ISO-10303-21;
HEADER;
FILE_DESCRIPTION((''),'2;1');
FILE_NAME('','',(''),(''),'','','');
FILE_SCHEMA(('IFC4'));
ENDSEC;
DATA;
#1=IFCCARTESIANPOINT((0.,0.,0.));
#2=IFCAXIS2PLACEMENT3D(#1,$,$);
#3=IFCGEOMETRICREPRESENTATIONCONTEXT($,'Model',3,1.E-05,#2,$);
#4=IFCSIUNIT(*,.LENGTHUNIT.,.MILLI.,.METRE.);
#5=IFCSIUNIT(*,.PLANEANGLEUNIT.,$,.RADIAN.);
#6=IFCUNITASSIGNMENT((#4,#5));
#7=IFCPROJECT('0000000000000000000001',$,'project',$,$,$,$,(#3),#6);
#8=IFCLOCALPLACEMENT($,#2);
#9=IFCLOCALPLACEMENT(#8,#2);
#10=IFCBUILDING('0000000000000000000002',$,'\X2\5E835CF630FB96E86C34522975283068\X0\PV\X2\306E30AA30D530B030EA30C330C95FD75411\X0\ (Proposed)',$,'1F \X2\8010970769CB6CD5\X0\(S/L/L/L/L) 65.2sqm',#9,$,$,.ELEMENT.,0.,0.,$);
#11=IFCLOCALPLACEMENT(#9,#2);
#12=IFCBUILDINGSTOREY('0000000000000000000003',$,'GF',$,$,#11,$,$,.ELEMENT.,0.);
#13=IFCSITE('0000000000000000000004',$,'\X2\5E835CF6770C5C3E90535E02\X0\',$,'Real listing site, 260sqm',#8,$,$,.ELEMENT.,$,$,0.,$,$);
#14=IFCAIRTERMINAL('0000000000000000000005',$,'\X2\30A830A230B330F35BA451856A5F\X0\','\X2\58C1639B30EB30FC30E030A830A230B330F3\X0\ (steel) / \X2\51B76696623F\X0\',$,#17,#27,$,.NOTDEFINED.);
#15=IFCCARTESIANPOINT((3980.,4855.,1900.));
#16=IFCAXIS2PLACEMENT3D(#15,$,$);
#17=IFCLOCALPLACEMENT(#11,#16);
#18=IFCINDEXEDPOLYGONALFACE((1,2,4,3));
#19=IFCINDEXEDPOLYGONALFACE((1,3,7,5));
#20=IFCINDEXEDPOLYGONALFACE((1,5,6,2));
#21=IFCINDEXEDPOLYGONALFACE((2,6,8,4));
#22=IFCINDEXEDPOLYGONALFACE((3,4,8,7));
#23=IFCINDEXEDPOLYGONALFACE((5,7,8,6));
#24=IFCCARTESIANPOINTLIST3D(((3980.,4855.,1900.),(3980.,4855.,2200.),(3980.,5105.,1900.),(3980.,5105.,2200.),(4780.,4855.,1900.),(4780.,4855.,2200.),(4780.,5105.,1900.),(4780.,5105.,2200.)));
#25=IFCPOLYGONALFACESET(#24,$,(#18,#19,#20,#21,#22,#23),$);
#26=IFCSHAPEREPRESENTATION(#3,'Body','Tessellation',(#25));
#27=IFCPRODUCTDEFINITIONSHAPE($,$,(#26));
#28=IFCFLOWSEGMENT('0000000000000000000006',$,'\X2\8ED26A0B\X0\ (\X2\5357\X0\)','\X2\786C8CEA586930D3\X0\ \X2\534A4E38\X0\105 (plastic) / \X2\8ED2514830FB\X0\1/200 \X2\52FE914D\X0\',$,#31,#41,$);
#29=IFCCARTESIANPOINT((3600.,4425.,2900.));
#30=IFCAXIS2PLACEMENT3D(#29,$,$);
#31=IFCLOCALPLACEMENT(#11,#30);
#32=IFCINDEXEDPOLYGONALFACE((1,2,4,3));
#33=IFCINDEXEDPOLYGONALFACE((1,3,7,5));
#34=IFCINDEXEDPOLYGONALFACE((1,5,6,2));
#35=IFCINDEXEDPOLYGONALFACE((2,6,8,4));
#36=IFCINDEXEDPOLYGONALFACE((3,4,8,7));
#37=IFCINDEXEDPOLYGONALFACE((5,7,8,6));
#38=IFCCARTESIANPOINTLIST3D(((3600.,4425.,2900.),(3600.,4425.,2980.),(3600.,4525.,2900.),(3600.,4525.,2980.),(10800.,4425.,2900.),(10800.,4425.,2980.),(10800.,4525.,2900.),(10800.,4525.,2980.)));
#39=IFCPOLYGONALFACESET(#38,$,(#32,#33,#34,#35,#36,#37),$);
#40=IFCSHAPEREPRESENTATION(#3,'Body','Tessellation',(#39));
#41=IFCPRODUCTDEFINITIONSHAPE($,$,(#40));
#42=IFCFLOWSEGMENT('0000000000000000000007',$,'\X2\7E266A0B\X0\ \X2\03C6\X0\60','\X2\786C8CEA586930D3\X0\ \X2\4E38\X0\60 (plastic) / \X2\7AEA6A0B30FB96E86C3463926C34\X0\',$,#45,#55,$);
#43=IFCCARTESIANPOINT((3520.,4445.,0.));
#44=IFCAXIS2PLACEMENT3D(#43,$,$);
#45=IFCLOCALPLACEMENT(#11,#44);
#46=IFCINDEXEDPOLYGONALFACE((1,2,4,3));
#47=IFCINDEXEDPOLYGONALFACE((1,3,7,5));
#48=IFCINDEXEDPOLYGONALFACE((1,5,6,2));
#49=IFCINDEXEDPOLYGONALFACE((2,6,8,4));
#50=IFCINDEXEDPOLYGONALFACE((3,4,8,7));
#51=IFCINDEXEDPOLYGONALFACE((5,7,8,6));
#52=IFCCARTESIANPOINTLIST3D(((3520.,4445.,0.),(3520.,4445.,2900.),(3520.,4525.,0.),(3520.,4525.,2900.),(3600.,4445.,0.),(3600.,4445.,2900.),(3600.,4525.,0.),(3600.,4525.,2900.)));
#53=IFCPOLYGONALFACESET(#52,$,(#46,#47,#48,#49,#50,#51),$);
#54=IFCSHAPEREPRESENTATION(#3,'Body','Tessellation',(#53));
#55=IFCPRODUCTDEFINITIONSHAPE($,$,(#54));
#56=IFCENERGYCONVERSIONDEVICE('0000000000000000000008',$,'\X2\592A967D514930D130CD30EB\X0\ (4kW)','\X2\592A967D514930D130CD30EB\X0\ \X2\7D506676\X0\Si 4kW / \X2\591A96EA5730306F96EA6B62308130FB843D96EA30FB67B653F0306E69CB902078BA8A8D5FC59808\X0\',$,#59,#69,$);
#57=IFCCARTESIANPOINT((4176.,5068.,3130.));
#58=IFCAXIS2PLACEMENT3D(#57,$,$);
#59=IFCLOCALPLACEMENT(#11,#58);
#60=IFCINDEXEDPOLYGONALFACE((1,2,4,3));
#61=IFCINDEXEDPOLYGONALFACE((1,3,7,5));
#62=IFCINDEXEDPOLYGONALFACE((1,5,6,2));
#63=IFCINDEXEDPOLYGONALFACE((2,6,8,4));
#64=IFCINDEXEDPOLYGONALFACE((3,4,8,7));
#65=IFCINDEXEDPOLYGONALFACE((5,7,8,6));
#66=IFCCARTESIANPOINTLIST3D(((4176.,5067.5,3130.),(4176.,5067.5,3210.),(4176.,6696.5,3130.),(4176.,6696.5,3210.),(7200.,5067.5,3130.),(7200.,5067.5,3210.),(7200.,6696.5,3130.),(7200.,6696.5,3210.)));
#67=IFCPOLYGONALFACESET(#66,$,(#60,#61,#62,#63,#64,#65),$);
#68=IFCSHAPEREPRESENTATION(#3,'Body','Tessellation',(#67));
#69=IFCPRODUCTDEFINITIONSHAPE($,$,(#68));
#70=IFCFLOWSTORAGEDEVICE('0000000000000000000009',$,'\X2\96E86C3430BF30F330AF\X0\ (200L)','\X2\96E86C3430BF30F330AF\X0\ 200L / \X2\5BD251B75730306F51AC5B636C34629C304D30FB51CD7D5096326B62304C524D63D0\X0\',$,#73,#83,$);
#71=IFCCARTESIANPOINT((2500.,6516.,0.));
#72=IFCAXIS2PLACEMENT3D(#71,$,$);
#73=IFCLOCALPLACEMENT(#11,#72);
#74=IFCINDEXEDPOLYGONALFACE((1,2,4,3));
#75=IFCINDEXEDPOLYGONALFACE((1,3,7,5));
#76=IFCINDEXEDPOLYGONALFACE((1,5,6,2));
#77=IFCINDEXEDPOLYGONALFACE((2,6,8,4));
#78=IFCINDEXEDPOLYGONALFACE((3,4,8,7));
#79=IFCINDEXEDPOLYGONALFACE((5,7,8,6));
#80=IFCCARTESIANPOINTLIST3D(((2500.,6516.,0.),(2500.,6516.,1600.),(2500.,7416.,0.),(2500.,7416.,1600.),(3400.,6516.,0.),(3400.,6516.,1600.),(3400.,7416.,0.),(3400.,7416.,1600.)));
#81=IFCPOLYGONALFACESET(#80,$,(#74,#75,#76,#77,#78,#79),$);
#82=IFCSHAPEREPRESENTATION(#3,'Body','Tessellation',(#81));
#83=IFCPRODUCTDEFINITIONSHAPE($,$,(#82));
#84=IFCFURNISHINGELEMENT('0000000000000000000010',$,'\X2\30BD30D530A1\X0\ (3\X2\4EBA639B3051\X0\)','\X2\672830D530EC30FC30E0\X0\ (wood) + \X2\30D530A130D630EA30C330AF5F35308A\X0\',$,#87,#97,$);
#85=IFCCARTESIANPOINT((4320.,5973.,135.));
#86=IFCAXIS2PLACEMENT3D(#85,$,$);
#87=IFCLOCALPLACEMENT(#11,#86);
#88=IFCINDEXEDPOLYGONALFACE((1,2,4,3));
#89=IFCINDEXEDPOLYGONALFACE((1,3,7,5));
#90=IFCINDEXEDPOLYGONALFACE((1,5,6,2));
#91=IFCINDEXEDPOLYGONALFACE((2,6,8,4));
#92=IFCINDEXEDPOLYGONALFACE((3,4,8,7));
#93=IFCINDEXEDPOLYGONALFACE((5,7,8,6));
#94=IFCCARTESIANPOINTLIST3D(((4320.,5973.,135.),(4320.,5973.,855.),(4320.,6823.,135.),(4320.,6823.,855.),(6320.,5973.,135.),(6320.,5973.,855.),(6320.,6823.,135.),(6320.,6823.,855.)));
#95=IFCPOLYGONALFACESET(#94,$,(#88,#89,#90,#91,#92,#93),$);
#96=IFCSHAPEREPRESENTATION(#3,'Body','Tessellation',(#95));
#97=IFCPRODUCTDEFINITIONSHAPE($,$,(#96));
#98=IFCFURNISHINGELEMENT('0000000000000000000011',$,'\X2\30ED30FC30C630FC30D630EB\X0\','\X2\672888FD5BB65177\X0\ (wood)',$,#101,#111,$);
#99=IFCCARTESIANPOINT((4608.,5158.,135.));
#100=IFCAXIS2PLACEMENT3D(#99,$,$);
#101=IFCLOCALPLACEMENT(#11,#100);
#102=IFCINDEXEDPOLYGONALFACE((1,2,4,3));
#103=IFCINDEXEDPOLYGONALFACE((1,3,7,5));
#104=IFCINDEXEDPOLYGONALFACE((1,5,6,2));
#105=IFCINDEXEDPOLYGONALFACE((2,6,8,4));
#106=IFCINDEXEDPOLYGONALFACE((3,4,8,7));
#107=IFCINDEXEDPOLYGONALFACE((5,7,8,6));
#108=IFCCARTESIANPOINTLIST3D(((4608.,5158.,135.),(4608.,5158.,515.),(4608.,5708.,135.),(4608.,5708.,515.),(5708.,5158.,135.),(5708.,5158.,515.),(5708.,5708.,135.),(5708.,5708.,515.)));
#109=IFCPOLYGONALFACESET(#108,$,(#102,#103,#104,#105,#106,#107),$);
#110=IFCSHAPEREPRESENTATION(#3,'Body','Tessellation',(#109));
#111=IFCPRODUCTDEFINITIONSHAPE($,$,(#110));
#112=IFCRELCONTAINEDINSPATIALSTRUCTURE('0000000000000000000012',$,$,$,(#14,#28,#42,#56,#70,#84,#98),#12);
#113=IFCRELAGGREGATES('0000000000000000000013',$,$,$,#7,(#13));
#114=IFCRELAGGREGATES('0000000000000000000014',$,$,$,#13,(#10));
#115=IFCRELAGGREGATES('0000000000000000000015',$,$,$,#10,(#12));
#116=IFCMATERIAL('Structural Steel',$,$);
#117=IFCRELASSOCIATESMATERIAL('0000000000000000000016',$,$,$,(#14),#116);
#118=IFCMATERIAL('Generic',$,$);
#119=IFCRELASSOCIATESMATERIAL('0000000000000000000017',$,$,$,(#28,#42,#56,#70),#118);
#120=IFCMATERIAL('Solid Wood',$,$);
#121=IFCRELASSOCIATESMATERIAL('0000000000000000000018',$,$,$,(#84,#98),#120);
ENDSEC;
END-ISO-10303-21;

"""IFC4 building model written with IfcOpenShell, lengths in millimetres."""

from ifc_helpers import new_model, si_unit, frame, frame_2d, origin, place, context, project, spatial, rectangle, extrude, material, element, save


model = new_model("IFC4")

# Units and contexts
model_context = context("Model", 3, precision=1e-05, world=origin())
ifc_project = project(units=[si_unit("LENGTHUNIT", "METRE", prefix="MILLI"), si_unit("PLANEANGLEUNIT", "RADIAN")], contexts=[model_context])

# Site, building, storey
site_placement = place(None, origin())
site = spatial("IfcSite", under=ifc_project, at=site_placement, Name="広島県尾道市", ObjectType="Real listing site, 260sqm", CompositionType="ELEMENT", RefElevation=0.0)
building_placement = place(site_placement, origin())
building = spatial("IfcBuilding", under=site, at=building_placement, Name="広島・雨水利用とPVのオフグリッド志向 (Proposed)", ObjectType="1F 耐震構法(S/L/L/L/L) 65.2sqm", CompositionType="ELEMENT", ElevationOfRefHeight=0.0, ElevationOfTerrain=0.0)
storey_placement = place(building_placement, origin())
storey = spatial("IfcBuildingStorey", under=building, at=storey_placement, Name="GF", CompositionType="ELEMENT", Elevation=0.0)

# Shared definitions
ifc_material_1 = material(Name="Solid Wood")

# Shared definitions
ifc_material_2 = material(Name="Structural Steel")

# Shared definitions
ifc_material_3 = material(Name="Generic")

# Air terminal
air_terminal_placement = place(storey_placement, frame((3980.0, 4855.0, 1900.0)))
element("IfcAirTerminal", 1, at=air_terminal_placement, inside=storey, material=ifc_material_2, Name="エアコン室内機", Description="壁掛ルームエアコン (steel) / 冷暖房", PredefinedType="NOTDEFINED", context=model_context, shape_type="SweptSolid", body=[
    extrude(rectangle(XDim=800.0, YDim=250.0, at=frame_2d((400.0, 125.0))), frame((3980.0, 4855.0, 1900.0)), (0.0, 0.0, 1.0), 300.0),
])

# Flow segments
flow_segment_1_placement = place(storey_placement, frame((3600.0, 4425.0, 2900.0)))
element("IfcFlowSegment", 2, at=flow_segment_1_placement, inside=storey, material=ifc_material_3, Name="軒樋 (南)", Description="硬質塩ビ 半丸105 (plastic) / 軒先・1/200 勾配", context=model_context, shape_type="SweptSolid", body=[
    extrude(rectangle(XDim=7200.0, YDim=100.0, at=frame_2d((3600.0, 50.0))), frame((3600.0, 4425.0, 2900.0)), (0.0, 0.0, 1.0), 80.0),
])
flow_segment_2_placement = place(storey_placement, frame((3520.0, 4445.0, 0.0)))
element("IfcFlowSegment", 3, at=flow_segment_2_placement, inside=storey, material=ifc_material_3, Name="縦樋 φ60", Description="硬質塩ビ 丸60 (plastic) / 竪樋・雨水排水", context=model_context, shape_type="SweptSolid", body=[
    extrude(rectangle(XDim=80.0, YDim=80.0, at=frame_2d((40.0, 40.0))), frame((3520.0, 4445.0, 0.0)), (0.0, 0.0, 1.0), 2900.0),
])

# Energy conversion device
energy_conversion_device_placement = place(storey_placement, frame((4176.0, 5068.0, 3130.0)))
element("IfcEnergyConversionDevice", 4, at=energy_conversion_device_placement, inside=storey, material=ifc_material_3, Name="太陽光パネル (4kW)", Description="太陽光パネル 結晶Si 4kW / 多雪地は雪止め・落雪・架台の構造確認必須", context=model_context, shape_type="SweptSolid", body=[
    extrude(rectangle(XDim=3024.0, YDim=1629.0, at=frame_2d((1512.0, 814.0))), frame((4176.0, 5068.0, 3130.0)), (0.0, 0.0, 1.0), 80.0),
])

# Flow storage device
flow_storage_device_placement = place(storey_placement, frame((2500.0, 6516.0, 0.0)))
element("IfcFlowStorageDevice", 5, at=flow_storage_device_placement, inside=storey, material=ifc_material_3, Name="雨水タンク (200L)", Description="雨水タンク 200L / 寒冷地は冬季水抜き・凍結防止が前提", context=model_context, shape_type="SweptSolid", body=[
    extrude(rectangle(XDim=900.0, YDim=900.0, at=frame_2d((450.0, 450.0))), frame((2500.0, 6516.0, 0.0)), (0.0, 0.0, 1.0), 1600.0),
])

# Furnishing elements
furnishing_1_placement = place(storey_placement, frame((4320.0, 5973.0, 135.0)))
element("IfcFurnishingElement", 6, at=furnishing_1_placement, inside=storey, material=ifc_material_1, Name="ソファ (3人掛け)", Description="木フレーム (wood) + ファブリック張り", context=model_context, shape_type="SweptSolid", body=[
    extrude(rectangle(XDim=2000.0, YDim=850.0, at=frame_2d((1000.0, 425.0))), frame((4320.0, 5973.0, 135.0)), (0.0, 0.0, 1.0), 720.0),
])
furnishing_2_placement = place(storey_placement, frame((4608.0, 5158.0, 135.0)))
element("IfcFurnishingElement", 7, at=furnishing_2_placement, inside=storey, material=ifc_material_1, Name="ローテーブル", Description="木製家具 (wood)", context=model_context, shape_type="SweptSolid", body=[
    extrude(rectangle(XDim=1100.0, YDim=550.0, at=frame_2d((550.0, 275.0))), frame((4608.0, 5158.0, 135.0)), (0.0, 0.0, 1.0), 380.0),
])

save(model, "model.ifc")
